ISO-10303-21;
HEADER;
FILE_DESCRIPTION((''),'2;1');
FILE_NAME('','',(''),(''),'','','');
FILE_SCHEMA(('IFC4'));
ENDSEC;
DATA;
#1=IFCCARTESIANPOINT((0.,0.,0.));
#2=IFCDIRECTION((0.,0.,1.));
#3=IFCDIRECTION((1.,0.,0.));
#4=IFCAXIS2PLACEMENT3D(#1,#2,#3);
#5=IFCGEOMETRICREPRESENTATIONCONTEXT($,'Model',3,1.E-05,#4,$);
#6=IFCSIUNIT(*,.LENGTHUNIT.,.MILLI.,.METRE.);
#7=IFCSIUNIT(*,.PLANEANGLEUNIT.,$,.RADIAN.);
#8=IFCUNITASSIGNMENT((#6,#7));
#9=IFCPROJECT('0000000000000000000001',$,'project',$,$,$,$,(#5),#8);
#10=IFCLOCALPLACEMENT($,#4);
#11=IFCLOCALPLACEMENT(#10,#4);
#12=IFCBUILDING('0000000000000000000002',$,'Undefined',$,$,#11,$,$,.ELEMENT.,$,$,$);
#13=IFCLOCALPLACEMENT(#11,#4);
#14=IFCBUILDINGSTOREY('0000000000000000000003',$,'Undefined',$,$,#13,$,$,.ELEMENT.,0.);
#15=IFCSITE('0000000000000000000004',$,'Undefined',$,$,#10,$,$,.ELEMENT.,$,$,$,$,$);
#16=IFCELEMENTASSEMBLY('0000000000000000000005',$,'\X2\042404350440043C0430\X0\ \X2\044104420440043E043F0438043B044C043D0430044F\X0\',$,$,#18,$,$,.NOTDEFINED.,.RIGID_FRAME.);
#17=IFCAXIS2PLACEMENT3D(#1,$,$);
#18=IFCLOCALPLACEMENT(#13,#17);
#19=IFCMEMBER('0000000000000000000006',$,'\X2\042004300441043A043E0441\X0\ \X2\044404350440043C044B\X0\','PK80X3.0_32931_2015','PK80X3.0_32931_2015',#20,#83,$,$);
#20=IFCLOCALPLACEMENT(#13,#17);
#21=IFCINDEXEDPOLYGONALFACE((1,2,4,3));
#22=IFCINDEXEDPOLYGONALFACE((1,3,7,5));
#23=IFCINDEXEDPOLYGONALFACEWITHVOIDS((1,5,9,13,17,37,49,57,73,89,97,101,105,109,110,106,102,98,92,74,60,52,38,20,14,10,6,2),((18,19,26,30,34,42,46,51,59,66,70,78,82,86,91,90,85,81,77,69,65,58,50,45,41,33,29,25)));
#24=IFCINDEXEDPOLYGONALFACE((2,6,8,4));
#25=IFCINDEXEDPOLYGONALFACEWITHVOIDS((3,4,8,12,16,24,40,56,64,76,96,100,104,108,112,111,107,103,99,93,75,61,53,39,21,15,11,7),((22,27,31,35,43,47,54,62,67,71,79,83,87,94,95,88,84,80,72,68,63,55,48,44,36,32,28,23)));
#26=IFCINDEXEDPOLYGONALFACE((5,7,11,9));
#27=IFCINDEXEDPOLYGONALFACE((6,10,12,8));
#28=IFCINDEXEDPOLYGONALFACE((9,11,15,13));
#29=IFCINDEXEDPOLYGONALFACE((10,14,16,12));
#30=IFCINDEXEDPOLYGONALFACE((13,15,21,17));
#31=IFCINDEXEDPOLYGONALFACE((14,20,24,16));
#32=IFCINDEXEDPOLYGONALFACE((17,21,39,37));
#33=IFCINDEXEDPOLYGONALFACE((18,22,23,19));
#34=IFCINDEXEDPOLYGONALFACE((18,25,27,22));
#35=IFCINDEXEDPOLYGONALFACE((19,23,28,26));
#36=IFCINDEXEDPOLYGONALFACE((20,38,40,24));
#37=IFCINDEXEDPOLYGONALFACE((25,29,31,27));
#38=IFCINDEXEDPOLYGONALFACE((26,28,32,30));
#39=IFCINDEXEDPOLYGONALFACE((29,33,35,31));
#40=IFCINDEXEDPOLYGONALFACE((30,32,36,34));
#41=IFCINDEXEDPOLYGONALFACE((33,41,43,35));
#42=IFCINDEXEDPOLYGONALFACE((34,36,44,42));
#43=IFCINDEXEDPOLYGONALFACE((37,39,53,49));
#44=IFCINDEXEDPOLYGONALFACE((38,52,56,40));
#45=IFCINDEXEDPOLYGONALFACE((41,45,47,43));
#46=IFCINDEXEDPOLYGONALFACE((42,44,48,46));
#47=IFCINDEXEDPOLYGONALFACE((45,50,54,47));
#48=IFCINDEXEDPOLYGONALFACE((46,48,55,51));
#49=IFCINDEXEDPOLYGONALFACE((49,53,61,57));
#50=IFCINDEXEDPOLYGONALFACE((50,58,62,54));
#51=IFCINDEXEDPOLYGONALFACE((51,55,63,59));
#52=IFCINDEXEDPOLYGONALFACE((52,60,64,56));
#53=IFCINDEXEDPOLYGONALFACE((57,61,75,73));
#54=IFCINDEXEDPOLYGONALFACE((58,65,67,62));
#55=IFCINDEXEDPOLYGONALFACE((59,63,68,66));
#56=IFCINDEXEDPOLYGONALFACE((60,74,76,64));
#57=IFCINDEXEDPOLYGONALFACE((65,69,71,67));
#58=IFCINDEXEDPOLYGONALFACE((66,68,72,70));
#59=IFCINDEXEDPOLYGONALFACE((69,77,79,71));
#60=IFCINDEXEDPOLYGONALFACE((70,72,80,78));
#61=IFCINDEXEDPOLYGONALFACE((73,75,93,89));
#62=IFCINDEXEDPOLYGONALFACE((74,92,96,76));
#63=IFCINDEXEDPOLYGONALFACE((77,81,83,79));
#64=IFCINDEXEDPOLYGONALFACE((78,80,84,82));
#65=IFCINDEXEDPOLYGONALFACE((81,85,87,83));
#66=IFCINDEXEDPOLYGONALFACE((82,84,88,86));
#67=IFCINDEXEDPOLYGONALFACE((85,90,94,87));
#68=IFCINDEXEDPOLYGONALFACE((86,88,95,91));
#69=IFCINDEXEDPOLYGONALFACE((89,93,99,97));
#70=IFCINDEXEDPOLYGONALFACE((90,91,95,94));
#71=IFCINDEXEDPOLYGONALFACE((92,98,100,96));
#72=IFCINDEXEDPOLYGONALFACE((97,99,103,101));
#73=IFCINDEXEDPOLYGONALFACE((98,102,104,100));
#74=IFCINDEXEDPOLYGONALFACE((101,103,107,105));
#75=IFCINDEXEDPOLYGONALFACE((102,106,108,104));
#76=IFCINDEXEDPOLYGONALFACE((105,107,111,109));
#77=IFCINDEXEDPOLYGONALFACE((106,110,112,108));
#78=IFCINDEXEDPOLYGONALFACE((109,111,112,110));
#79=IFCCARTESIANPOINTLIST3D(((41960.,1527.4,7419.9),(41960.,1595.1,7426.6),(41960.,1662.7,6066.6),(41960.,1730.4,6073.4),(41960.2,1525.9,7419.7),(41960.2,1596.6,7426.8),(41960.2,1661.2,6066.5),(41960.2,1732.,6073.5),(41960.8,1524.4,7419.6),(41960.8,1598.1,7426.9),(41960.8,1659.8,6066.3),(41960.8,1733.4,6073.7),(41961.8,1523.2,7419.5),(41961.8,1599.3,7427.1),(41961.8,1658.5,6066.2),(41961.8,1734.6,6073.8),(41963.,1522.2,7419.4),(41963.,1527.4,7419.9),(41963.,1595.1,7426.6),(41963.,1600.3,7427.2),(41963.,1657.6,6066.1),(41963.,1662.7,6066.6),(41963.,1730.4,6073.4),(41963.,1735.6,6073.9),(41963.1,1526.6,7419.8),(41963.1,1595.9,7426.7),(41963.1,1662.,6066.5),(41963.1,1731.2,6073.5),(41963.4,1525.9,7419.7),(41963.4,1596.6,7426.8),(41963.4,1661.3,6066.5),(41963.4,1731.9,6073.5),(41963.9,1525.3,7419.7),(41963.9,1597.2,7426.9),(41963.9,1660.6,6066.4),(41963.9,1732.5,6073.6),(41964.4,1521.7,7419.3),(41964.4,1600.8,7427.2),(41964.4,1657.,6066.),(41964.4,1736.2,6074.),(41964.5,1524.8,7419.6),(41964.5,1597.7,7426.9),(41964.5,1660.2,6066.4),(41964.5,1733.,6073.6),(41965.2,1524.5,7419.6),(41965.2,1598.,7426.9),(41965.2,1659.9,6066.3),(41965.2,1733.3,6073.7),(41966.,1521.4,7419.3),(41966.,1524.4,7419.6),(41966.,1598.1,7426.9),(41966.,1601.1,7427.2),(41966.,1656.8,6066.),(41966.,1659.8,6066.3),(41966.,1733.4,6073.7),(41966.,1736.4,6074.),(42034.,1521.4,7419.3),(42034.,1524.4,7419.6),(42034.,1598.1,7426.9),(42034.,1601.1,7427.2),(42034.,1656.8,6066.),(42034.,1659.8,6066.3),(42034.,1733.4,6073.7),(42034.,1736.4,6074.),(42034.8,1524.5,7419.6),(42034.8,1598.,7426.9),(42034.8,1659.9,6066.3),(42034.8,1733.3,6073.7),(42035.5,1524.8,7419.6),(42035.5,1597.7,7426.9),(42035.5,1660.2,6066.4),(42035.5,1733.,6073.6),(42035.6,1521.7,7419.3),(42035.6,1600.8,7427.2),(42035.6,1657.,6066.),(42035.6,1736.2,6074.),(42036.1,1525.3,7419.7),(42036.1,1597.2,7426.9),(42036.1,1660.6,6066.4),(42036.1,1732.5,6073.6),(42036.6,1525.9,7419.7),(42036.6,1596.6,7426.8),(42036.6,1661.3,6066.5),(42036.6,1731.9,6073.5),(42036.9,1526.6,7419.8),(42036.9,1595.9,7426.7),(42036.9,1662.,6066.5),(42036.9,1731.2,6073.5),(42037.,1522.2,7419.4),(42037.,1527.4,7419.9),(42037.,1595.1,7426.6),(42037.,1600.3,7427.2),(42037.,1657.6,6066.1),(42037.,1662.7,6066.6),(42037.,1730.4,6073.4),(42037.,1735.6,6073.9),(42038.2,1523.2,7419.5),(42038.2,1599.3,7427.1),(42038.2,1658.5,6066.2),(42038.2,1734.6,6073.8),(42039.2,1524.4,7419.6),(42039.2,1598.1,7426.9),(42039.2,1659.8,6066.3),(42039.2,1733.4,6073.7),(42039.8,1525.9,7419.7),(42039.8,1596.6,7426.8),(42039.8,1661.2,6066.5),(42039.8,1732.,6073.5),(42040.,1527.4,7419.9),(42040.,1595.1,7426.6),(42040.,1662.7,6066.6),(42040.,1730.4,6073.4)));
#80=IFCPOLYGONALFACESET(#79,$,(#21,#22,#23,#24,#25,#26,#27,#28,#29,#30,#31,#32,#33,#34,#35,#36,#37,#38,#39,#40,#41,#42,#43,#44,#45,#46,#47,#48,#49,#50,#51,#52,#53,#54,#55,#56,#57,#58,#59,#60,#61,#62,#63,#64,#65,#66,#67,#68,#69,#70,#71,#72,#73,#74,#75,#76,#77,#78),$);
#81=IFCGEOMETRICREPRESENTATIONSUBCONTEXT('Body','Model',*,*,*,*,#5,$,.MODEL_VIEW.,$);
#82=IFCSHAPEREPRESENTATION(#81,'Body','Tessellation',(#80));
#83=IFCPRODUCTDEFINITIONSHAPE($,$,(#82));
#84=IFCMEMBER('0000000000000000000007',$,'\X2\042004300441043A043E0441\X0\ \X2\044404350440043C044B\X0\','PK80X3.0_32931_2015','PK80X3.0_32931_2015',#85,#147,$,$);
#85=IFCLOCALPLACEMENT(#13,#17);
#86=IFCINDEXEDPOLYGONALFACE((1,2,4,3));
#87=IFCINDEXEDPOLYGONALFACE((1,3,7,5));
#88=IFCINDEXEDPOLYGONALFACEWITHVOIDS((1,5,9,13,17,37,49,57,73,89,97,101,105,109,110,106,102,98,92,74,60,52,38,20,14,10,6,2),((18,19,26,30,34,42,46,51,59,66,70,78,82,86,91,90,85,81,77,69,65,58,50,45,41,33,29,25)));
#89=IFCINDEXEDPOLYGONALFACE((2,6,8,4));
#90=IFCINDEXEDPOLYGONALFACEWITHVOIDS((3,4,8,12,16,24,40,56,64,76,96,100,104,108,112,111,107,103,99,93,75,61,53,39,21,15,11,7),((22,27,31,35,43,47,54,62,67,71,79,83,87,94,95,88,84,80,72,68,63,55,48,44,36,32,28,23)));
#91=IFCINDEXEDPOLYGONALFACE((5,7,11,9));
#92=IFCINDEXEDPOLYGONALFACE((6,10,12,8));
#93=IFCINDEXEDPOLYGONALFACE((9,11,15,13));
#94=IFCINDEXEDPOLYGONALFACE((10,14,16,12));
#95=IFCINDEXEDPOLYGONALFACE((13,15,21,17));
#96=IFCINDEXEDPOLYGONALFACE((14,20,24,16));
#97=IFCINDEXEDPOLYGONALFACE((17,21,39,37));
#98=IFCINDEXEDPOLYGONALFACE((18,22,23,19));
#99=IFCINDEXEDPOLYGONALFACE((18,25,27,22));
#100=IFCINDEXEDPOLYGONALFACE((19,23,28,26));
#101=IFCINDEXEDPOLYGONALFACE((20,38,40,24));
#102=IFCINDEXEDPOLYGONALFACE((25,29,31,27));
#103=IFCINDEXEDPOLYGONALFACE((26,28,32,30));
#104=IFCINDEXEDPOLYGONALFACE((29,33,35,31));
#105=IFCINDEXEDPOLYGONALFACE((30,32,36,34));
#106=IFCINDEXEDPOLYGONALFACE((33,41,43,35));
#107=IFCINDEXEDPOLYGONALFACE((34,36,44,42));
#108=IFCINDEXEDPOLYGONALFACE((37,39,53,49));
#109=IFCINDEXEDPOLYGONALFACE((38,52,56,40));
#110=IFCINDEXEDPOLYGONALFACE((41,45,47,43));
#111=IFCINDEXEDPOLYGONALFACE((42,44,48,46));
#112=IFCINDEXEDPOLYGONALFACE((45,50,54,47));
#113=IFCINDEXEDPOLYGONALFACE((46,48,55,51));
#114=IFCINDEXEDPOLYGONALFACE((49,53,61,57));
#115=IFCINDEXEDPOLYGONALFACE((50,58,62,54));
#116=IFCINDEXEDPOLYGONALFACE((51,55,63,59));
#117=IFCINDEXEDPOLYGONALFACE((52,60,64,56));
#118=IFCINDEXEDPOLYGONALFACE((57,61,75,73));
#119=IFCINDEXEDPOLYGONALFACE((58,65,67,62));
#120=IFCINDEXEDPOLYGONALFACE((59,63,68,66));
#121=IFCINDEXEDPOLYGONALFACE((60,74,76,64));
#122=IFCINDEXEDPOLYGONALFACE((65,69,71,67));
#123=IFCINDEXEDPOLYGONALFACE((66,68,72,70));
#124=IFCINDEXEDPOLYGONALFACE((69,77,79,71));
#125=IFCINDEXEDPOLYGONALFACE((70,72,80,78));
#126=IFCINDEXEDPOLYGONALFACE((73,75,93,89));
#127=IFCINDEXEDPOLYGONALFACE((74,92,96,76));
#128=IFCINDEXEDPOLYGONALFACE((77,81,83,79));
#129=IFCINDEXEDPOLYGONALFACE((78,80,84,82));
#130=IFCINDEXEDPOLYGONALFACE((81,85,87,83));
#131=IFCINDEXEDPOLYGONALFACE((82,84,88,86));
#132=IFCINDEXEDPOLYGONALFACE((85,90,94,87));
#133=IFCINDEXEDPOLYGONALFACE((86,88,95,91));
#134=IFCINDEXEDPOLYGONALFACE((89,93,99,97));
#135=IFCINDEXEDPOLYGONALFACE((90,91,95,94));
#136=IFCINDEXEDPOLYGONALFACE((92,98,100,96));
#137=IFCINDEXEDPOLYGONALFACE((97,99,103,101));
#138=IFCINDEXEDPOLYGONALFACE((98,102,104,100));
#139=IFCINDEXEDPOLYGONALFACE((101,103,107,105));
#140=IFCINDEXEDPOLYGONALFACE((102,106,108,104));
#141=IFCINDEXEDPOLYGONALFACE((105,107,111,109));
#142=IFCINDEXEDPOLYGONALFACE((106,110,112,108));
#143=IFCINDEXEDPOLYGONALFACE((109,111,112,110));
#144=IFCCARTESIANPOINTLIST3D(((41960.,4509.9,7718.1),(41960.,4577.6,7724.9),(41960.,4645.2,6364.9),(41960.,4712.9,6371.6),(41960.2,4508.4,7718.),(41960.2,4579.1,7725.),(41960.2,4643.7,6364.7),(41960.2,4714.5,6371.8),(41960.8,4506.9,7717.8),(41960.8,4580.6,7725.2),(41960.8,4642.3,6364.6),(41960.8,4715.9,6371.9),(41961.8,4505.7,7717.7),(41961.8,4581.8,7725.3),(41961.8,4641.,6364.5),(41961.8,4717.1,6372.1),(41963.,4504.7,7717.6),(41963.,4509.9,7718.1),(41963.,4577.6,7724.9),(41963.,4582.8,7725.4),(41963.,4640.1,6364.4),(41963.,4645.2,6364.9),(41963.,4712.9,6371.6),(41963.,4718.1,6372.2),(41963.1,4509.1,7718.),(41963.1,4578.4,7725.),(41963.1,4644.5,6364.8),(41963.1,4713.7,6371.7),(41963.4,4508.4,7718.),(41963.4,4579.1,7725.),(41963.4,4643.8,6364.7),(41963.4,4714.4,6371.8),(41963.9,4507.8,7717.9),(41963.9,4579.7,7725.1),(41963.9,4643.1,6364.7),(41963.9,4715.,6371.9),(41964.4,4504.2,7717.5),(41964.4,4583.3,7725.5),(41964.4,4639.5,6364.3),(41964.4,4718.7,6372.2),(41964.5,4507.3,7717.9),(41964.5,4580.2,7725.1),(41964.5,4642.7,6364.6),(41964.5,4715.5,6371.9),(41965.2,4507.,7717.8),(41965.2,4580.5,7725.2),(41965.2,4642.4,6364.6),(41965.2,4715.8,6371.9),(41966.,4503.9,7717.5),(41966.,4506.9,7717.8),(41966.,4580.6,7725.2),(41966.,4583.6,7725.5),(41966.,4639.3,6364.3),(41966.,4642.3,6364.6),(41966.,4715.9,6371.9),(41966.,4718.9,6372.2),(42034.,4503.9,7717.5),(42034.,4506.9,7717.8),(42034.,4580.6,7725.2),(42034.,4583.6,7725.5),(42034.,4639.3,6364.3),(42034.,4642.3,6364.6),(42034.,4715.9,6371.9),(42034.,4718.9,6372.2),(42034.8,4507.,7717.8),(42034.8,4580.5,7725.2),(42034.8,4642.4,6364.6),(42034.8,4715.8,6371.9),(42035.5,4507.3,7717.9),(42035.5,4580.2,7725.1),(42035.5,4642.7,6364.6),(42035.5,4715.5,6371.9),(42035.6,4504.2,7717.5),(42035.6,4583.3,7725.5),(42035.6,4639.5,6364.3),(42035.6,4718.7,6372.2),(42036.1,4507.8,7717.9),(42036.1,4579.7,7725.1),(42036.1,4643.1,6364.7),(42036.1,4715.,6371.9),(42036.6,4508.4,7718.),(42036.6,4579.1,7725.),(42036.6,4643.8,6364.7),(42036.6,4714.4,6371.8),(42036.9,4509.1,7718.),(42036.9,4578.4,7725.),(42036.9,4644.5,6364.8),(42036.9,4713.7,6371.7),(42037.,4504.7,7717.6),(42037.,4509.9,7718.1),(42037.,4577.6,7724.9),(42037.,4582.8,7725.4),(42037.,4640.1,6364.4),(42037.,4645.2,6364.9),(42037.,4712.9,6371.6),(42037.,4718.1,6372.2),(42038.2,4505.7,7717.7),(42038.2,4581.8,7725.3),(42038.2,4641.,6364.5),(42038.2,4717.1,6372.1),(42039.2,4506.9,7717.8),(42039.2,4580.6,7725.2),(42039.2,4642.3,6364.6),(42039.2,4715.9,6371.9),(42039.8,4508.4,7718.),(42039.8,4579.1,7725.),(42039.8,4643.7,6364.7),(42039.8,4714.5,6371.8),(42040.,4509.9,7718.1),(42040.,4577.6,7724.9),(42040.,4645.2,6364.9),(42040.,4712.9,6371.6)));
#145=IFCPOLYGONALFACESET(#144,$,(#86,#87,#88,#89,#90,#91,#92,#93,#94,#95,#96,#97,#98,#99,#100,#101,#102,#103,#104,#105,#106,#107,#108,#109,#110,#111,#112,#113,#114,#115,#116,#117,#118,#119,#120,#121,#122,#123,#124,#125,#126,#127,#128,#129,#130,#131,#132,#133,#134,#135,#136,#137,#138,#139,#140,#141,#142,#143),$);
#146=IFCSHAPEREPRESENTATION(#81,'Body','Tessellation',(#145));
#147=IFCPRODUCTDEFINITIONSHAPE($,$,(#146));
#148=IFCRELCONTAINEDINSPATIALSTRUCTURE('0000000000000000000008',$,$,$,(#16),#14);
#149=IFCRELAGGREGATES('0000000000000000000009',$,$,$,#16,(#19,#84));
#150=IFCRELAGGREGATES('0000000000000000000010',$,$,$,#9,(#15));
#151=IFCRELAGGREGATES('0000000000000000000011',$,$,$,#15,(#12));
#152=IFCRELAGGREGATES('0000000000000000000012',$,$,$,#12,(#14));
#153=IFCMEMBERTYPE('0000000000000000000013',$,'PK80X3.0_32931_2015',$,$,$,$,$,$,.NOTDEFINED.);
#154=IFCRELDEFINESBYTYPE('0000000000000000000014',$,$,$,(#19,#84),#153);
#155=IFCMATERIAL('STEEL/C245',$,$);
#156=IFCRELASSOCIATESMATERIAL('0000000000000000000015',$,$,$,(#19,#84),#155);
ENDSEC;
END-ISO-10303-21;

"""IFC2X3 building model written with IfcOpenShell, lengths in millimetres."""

from ifc_helpers import new_model, si_unit, frame, origin_with_axes, origin_2d_with_axis, place, context, subcontext, project, spatial, hollow_rectangle, extrude, material, type_object, element, aggregate, save


model = new_model("IFC2X3")

# Units and contexts
model_context = context("Model", 3, precision=1e-05, world=origin_with_axes())
body_context = subcontext(model_context, "Body", "Model", "MODEL_VIEW")
ifc_project = project(units=[si_unit("LENGTHUNIT", "METRE", prefix="MILLI"), si_unit("PLANEANGLEUNIT", "RADIAN")], contexts=[model_context])

# Site, building, storey
site_placement = place(None, origin_with_axes())
site = spatial("IfcSite", under=ifc_project, at=site_placement, Name="Undefined", CompositionType="ELEMENT")
building_placement = place(site_placement, origin_with_axes())
building = spatial("IfcBuilding", under=site, at=building_placement, Name="Undefined", CompositionType="ELEMENT")
storey_placement = place(building_placement, origin_with_axes())
storey = spatial("IfcBuildingStorey", under=building, at=storey_placement, Name="Undefined", CompositionType="ELEMENT", Elevation=0.0)

# Shared definitions
ifc_material_1 = material(Name="STEEL/C245")

# Shared definitions
member_type_1 = type_object("IfcMemberType", Name="PK80X3.0_32931_2015", PredefinedType="NOTDEFINED")

# Element assembly, members
assembly_1_placement = place(storey_placement, origin_with_axes())
assembly_1 = element("IfcElementAssembly", 1, at=assembly_1_placement, inside=storey, Name="Ферма стропильная", AssemblyPlace="NOTDEFINED", PredefinedType="RIGID_FRAME")
member_1_placement = place(assembly_1_placement, frame((42000.0, 1561.3, 7423.3), z_axis=(0.0, 0.995037, 0.099504), x_axis=(0.0, 0.099504, -0.995037)))
member_1 = element("IfcMember", 2, at=member_1_placement, type_object=member_type_1, material=ifc_material_1, Name="Раскос фермы", Description="PK80X3.0_32931_2015", ObjectType="PK80X3.0_32931_2015", context=body_context, shape_type="SweptSolid", body=[
    extrude(hollow_rectangle(XDim=80.0, YDim=80.0, WallThickness=3.0, InnerFilletRadius=3.0, OuterFilletRadius=6.0, at=origin_2d_with_axis()), frame((1360.0, 0.0, 0.0), z_axis=(-1.0, 0.0, 0.0), x_axis=(0.0, -1.0, 0.0)), (0.0, 0.0, 1.0), 1360.0),
])
member_2_placement = place(assembly_1_placement, frame((42000.0, 4543.8, 7721.5), z_axis=(0.0, 0.995037, 0.099504), x_axis=(0.0, 0.099504, -0.995037)))
member_2 = element("IfcMember", 3, at=member_2_placement, type_object=member_type_1, material=ifc_material_1, Name="Раскос фермы", Description="PK80X3.0_32931_2015", ObjectType="PK80X3.0_32931_2015", context=body_context, shape_type="SweptSolid", body=[
    extrude(hollow_rectangle(XDim=80.0, YDim=80.0, WallThickness=3.0, InnerFilletRadius=3.0, OuterFilletRadius=6.0, at=origin_2d_with_axis()), frame((1360.0, 0.0, 0.0), z_axis=(-1.0, 0.0, 0.0), x_axis=(0.0, -1.0, 0.0)), (0.0, 0.0, 1.0), 1360.0),
])
aggregate(assembly_1, [member_1, member_2])

save(model, "model.ifc")
